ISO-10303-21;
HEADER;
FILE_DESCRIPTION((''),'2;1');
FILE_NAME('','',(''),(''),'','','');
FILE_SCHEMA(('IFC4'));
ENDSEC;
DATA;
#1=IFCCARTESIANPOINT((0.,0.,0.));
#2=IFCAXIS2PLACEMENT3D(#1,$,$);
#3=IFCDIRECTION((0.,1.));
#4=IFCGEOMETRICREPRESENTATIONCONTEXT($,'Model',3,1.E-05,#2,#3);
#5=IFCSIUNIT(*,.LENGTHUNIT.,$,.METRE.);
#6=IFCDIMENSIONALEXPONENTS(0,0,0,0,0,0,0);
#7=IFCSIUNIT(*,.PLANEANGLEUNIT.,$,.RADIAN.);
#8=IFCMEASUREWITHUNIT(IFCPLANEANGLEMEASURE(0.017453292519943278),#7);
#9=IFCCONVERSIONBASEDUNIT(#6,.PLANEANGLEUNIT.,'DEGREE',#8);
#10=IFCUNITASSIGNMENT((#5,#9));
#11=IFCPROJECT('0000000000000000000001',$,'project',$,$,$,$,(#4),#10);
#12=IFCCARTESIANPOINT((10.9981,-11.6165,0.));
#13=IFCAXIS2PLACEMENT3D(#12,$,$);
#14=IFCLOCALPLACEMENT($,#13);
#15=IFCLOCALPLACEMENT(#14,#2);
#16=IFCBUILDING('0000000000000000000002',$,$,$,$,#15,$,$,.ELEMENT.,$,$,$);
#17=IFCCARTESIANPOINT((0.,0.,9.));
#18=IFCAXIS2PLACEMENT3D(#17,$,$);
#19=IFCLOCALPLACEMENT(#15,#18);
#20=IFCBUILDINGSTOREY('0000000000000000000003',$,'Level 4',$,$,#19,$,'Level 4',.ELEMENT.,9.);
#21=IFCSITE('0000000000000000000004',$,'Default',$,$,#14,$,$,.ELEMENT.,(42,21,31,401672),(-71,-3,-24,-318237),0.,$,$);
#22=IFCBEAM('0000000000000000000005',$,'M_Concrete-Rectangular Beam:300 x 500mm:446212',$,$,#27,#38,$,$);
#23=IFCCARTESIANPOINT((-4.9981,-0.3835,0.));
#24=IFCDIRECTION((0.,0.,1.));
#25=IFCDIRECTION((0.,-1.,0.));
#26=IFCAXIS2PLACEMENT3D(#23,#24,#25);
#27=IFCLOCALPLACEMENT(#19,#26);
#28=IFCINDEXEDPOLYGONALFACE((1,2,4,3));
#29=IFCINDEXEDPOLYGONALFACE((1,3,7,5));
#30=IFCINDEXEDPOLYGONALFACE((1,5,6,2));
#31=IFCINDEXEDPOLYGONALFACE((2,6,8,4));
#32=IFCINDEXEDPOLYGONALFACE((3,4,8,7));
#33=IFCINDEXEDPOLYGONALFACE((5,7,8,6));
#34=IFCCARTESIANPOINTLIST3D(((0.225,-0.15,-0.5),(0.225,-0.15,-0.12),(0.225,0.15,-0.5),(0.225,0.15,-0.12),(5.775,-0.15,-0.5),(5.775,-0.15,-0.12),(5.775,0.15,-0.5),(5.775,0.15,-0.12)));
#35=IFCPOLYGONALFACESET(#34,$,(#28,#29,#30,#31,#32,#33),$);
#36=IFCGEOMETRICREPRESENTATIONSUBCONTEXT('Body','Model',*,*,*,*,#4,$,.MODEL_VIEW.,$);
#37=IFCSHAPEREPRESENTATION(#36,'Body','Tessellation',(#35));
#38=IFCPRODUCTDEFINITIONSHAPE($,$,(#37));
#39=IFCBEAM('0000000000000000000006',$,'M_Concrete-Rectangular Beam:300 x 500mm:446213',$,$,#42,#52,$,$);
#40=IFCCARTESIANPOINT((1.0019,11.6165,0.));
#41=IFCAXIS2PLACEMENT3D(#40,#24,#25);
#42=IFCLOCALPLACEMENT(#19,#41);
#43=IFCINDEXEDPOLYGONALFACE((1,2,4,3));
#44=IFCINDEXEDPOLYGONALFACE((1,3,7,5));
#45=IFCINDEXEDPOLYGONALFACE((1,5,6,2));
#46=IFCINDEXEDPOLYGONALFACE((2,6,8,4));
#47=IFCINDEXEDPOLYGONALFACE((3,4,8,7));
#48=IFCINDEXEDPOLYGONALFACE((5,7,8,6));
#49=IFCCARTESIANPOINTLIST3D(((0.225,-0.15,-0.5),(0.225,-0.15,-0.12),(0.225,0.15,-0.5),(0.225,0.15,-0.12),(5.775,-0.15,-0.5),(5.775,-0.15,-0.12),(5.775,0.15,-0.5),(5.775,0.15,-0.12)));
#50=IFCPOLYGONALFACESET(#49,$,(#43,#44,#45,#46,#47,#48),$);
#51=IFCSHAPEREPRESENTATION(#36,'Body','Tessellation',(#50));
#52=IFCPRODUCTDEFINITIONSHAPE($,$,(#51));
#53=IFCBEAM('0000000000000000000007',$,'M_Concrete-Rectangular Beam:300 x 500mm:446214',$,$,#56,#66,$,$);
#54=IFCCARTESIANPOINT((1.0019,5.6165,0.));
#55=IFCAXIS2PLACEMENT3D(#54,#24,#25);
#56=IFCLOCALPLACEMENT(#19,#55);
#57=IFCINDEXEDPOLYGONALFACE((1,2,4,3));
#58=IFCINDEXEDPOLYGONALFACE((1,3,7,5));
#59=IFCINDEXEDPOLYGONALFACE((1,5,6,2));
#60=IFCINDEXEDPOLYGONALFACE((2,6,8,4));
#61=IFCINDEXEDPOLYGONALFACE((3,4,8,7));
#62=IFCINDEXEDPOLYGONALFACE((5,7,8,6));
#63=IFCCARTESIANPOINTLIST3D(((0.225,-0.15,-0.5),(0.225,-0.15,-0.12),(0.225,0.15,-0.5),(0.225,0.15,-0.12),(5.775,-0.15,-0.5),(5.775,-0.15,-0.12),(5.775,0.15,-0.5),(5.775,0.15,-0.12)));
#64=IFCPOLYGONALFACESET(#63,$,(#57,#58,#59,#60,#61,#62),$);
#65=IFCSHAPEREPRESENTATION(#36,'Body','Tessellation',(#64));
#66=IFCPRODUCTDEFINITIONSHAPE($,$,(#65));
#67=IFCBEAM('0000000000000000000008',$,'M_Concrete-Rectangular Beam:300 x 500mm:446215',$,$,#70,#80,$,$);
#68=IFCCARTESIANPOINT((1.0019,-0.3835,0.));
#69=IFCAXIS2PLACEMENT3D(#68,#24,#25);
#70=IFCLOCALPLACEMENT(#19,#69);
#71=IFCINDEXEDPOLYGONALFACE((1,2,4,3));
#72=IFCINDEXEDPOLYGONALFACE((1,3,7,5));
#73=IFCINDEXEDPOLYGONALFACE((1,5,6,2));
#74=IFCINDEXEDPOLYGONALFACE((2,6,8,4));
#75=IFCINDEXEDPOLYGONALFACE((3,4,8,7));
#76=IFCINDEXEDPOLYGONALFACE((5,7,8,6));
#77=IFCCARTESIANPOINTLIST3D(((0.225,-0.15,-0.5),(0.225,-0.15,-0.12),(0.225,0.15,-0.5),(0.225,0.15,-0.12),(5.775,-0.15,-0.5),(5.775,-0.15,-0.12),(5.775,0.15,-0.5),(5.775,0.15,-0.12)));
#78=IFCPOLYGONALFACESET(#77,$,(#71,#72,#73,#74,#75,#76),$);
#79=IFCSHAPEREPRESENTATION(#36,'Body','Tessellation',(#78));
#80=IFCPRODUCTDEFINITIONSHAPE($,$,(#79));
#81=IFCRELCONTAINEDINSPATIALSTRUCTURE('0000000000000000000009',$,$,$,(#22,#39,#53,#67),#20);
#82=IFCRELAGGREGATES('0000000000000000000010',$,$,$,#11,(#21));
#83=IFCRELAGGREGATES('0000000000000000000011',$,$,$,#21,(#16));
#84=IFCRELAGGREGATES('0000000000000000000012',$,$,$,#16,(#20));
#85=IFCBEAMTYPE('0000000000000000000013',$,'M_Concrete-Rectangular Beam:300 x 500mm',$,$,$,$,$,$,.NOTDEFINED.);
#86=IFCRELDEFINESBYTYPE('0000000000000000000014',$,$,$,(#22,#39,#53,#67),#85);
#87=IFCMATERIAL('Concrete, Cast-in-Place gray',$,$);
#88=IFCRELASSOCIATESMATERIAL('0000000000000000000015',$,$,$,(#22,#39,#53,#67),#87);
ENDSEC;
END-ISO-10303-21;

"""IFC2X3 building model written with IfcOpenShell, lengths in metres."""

from ifc_helpers import new_model, entity, si_unit, converted_unit, direction, frame, frame_2d, origin, place, context, subcontext, project, spatial, rectangle, extrude, material, type_object, element, save


model = new_model("IFC2X3")

# Units and contexts
model_context = context("Model", 3, precision=1e-05, world=origin(), true_north=direction((0.0, 1.0)))
body_context = subcontext(model_context, "Body", "Model", "MODEL_VIEW")
ifc_project = project(units=[si_unit("LENGTHUNIT", "METRE"), converted_unit("PLANEANGLEUNIT", "DEGREE", entity("IfcPlaneAngleMeasure", 0.017453292519943278), si_unit("PLANEANGLEUNIT", "RADIAN"), dimensions=[0, 0, 0, 0, 0, 0, 0])], contexts=[model_context])

# Site, building, storey
site_placement = place(None, frame((10.9981, -11.6165, 0.0)))
site = spatial("IfcSite", under=ifc_project, at=site_placement, Name="Default", CompositionType="ELEMENT", RefLatitude=(42, 21, 31, 401672), RefLongitude=(-71, -3, -24, -318237), RefElevation=0.0)
building_placement = place(site_placement, origin())
building = spatial("IfcBuilding", under=site, at=building_placement, CompositionType="ELEMENT")
storey_placement = place(building_placement, frame((0.0, 0.0, 9.0)))
storey = spatial("IfcBuildingStorey", under=building, at=storey_placement, Name="Level 4", LongName="Level 4", CompositionType="ELEMENT", Elevation=9.0)

# Shared definitions
ifc_material_1 = material(Name="Concrete, Cast-in-Place gray")

# Beams
beam_type = type_object("IfcBeamType", Name="M_Concrete-Rectangular Beam:300 x 500mm", PredefinedType="NOTDEFINED")
beam_1_placement = place(storey_placement, frame((-4.9981, -0.3835, 0.0), z_axis=(0.0, 0.0, 1.0), x_axis=(0.0, -1.0, 0.0)))
element("IfcBeam", 1, at=beam_1_placement, inside=storey, type_object=beam_type, material=ifc_material_1, Name="M_Concrete-Rectangular Beam:300 x 500mm:446212", context=body_context, shape_type="SweptSolid", body=[
    extrude(rectangle(XDim=0.38, YDim=0.3, at=frame_2d((0.0, 0.0), x_axis=(1.0, 0.0))), frame((0.225, 0.0, -0.31), z_axis=(1.0, 0.0, 0.0), x_axis=(0.0, 0.0, -1.0)), (0.0, 0.0, 1.0), 5.55),
])
beam_2_placement = place(storey_placement, frame((1.0019, 11.6165, 0.0), z_axis=(0.0, 0.0, 1.0), x_axis=(0.0, -1.0, 0.0)))
element("IfcBeam", 2, at=beam_2_placement, inside=storey, type_object=beam_type, material=ifc_material_1, Name="M_Concrete-Rectangular Beam:300 x 500mm:446213", context=body_context, shape_type="SweptSolid", body=[
    extrude(rectangle(XDim=0.38, YDim=0.3, at=frame_2d((0.0, 0.0), x_axis=(1.0, 0.0))), frame((0.225, 0.0, -0.31), z_axis=(1.0, 0.0, 0.0), x_axis=(0.0, 0.0, -1.0)), (0.0, 0.0, 1.0), 5.55),
])
beam_3_placement = place(storey_placement, frame((1.0019, 5.6165, 0.0), z_axis=(0.0, 0.0, 1.0), x_axis=(0.0, -1.0, 0.0)))
element("IfcBeam", 3, at=beam_3_placement, inside=storey, type_object=beam_type, material=ifc_material_1, Name="M_Concrete-Rectangular Beam:300 x 500mm:446214", context=body_context, shape_type="SweptSolid", body=[
    extrude(rectangle(XDim=0.38, YDim=0.3, at=frame_2d((0.0, 0.0), x_axis=(1.0, 0.0))), frame((0.225, 0.0, -0.31), z_axis=(1.0, 0.0, 0.0), x_axis=(0.0, 0.0, -1.0)), (0.0, 0.0, 1.0), 5.55),
])
beam_4_placement = place(storey_placement, frame((1.0019, -0.3835, 0.0), z_axis=(0.0, 0.0, 1.0), x_axis=(0.0, -1.0, 0.0)))
element("IfcBeam", 4, at=beam_4_placement, inside=storey, type_object=beam_type, material=ifc_material_1, Name="M_Concrete-Rectangular Beam:300 x 500mm:446215", context=body_context, shape_type="SweptSolid", body=[
    extrude(rectangle(XDim=0.38, YDim=0.3, at=frame_2d((0.0, 0.0), x_axis=(1.0, 0.0))), frame((0.225, 0.0, -0.31), z_axis=(1.0, 0.0, 0.0), x_axis=(0.0, 0.0, -1.0)), (0.0, 0.0, 1.0), 5.55),
])

save(model, "model.ifc")
